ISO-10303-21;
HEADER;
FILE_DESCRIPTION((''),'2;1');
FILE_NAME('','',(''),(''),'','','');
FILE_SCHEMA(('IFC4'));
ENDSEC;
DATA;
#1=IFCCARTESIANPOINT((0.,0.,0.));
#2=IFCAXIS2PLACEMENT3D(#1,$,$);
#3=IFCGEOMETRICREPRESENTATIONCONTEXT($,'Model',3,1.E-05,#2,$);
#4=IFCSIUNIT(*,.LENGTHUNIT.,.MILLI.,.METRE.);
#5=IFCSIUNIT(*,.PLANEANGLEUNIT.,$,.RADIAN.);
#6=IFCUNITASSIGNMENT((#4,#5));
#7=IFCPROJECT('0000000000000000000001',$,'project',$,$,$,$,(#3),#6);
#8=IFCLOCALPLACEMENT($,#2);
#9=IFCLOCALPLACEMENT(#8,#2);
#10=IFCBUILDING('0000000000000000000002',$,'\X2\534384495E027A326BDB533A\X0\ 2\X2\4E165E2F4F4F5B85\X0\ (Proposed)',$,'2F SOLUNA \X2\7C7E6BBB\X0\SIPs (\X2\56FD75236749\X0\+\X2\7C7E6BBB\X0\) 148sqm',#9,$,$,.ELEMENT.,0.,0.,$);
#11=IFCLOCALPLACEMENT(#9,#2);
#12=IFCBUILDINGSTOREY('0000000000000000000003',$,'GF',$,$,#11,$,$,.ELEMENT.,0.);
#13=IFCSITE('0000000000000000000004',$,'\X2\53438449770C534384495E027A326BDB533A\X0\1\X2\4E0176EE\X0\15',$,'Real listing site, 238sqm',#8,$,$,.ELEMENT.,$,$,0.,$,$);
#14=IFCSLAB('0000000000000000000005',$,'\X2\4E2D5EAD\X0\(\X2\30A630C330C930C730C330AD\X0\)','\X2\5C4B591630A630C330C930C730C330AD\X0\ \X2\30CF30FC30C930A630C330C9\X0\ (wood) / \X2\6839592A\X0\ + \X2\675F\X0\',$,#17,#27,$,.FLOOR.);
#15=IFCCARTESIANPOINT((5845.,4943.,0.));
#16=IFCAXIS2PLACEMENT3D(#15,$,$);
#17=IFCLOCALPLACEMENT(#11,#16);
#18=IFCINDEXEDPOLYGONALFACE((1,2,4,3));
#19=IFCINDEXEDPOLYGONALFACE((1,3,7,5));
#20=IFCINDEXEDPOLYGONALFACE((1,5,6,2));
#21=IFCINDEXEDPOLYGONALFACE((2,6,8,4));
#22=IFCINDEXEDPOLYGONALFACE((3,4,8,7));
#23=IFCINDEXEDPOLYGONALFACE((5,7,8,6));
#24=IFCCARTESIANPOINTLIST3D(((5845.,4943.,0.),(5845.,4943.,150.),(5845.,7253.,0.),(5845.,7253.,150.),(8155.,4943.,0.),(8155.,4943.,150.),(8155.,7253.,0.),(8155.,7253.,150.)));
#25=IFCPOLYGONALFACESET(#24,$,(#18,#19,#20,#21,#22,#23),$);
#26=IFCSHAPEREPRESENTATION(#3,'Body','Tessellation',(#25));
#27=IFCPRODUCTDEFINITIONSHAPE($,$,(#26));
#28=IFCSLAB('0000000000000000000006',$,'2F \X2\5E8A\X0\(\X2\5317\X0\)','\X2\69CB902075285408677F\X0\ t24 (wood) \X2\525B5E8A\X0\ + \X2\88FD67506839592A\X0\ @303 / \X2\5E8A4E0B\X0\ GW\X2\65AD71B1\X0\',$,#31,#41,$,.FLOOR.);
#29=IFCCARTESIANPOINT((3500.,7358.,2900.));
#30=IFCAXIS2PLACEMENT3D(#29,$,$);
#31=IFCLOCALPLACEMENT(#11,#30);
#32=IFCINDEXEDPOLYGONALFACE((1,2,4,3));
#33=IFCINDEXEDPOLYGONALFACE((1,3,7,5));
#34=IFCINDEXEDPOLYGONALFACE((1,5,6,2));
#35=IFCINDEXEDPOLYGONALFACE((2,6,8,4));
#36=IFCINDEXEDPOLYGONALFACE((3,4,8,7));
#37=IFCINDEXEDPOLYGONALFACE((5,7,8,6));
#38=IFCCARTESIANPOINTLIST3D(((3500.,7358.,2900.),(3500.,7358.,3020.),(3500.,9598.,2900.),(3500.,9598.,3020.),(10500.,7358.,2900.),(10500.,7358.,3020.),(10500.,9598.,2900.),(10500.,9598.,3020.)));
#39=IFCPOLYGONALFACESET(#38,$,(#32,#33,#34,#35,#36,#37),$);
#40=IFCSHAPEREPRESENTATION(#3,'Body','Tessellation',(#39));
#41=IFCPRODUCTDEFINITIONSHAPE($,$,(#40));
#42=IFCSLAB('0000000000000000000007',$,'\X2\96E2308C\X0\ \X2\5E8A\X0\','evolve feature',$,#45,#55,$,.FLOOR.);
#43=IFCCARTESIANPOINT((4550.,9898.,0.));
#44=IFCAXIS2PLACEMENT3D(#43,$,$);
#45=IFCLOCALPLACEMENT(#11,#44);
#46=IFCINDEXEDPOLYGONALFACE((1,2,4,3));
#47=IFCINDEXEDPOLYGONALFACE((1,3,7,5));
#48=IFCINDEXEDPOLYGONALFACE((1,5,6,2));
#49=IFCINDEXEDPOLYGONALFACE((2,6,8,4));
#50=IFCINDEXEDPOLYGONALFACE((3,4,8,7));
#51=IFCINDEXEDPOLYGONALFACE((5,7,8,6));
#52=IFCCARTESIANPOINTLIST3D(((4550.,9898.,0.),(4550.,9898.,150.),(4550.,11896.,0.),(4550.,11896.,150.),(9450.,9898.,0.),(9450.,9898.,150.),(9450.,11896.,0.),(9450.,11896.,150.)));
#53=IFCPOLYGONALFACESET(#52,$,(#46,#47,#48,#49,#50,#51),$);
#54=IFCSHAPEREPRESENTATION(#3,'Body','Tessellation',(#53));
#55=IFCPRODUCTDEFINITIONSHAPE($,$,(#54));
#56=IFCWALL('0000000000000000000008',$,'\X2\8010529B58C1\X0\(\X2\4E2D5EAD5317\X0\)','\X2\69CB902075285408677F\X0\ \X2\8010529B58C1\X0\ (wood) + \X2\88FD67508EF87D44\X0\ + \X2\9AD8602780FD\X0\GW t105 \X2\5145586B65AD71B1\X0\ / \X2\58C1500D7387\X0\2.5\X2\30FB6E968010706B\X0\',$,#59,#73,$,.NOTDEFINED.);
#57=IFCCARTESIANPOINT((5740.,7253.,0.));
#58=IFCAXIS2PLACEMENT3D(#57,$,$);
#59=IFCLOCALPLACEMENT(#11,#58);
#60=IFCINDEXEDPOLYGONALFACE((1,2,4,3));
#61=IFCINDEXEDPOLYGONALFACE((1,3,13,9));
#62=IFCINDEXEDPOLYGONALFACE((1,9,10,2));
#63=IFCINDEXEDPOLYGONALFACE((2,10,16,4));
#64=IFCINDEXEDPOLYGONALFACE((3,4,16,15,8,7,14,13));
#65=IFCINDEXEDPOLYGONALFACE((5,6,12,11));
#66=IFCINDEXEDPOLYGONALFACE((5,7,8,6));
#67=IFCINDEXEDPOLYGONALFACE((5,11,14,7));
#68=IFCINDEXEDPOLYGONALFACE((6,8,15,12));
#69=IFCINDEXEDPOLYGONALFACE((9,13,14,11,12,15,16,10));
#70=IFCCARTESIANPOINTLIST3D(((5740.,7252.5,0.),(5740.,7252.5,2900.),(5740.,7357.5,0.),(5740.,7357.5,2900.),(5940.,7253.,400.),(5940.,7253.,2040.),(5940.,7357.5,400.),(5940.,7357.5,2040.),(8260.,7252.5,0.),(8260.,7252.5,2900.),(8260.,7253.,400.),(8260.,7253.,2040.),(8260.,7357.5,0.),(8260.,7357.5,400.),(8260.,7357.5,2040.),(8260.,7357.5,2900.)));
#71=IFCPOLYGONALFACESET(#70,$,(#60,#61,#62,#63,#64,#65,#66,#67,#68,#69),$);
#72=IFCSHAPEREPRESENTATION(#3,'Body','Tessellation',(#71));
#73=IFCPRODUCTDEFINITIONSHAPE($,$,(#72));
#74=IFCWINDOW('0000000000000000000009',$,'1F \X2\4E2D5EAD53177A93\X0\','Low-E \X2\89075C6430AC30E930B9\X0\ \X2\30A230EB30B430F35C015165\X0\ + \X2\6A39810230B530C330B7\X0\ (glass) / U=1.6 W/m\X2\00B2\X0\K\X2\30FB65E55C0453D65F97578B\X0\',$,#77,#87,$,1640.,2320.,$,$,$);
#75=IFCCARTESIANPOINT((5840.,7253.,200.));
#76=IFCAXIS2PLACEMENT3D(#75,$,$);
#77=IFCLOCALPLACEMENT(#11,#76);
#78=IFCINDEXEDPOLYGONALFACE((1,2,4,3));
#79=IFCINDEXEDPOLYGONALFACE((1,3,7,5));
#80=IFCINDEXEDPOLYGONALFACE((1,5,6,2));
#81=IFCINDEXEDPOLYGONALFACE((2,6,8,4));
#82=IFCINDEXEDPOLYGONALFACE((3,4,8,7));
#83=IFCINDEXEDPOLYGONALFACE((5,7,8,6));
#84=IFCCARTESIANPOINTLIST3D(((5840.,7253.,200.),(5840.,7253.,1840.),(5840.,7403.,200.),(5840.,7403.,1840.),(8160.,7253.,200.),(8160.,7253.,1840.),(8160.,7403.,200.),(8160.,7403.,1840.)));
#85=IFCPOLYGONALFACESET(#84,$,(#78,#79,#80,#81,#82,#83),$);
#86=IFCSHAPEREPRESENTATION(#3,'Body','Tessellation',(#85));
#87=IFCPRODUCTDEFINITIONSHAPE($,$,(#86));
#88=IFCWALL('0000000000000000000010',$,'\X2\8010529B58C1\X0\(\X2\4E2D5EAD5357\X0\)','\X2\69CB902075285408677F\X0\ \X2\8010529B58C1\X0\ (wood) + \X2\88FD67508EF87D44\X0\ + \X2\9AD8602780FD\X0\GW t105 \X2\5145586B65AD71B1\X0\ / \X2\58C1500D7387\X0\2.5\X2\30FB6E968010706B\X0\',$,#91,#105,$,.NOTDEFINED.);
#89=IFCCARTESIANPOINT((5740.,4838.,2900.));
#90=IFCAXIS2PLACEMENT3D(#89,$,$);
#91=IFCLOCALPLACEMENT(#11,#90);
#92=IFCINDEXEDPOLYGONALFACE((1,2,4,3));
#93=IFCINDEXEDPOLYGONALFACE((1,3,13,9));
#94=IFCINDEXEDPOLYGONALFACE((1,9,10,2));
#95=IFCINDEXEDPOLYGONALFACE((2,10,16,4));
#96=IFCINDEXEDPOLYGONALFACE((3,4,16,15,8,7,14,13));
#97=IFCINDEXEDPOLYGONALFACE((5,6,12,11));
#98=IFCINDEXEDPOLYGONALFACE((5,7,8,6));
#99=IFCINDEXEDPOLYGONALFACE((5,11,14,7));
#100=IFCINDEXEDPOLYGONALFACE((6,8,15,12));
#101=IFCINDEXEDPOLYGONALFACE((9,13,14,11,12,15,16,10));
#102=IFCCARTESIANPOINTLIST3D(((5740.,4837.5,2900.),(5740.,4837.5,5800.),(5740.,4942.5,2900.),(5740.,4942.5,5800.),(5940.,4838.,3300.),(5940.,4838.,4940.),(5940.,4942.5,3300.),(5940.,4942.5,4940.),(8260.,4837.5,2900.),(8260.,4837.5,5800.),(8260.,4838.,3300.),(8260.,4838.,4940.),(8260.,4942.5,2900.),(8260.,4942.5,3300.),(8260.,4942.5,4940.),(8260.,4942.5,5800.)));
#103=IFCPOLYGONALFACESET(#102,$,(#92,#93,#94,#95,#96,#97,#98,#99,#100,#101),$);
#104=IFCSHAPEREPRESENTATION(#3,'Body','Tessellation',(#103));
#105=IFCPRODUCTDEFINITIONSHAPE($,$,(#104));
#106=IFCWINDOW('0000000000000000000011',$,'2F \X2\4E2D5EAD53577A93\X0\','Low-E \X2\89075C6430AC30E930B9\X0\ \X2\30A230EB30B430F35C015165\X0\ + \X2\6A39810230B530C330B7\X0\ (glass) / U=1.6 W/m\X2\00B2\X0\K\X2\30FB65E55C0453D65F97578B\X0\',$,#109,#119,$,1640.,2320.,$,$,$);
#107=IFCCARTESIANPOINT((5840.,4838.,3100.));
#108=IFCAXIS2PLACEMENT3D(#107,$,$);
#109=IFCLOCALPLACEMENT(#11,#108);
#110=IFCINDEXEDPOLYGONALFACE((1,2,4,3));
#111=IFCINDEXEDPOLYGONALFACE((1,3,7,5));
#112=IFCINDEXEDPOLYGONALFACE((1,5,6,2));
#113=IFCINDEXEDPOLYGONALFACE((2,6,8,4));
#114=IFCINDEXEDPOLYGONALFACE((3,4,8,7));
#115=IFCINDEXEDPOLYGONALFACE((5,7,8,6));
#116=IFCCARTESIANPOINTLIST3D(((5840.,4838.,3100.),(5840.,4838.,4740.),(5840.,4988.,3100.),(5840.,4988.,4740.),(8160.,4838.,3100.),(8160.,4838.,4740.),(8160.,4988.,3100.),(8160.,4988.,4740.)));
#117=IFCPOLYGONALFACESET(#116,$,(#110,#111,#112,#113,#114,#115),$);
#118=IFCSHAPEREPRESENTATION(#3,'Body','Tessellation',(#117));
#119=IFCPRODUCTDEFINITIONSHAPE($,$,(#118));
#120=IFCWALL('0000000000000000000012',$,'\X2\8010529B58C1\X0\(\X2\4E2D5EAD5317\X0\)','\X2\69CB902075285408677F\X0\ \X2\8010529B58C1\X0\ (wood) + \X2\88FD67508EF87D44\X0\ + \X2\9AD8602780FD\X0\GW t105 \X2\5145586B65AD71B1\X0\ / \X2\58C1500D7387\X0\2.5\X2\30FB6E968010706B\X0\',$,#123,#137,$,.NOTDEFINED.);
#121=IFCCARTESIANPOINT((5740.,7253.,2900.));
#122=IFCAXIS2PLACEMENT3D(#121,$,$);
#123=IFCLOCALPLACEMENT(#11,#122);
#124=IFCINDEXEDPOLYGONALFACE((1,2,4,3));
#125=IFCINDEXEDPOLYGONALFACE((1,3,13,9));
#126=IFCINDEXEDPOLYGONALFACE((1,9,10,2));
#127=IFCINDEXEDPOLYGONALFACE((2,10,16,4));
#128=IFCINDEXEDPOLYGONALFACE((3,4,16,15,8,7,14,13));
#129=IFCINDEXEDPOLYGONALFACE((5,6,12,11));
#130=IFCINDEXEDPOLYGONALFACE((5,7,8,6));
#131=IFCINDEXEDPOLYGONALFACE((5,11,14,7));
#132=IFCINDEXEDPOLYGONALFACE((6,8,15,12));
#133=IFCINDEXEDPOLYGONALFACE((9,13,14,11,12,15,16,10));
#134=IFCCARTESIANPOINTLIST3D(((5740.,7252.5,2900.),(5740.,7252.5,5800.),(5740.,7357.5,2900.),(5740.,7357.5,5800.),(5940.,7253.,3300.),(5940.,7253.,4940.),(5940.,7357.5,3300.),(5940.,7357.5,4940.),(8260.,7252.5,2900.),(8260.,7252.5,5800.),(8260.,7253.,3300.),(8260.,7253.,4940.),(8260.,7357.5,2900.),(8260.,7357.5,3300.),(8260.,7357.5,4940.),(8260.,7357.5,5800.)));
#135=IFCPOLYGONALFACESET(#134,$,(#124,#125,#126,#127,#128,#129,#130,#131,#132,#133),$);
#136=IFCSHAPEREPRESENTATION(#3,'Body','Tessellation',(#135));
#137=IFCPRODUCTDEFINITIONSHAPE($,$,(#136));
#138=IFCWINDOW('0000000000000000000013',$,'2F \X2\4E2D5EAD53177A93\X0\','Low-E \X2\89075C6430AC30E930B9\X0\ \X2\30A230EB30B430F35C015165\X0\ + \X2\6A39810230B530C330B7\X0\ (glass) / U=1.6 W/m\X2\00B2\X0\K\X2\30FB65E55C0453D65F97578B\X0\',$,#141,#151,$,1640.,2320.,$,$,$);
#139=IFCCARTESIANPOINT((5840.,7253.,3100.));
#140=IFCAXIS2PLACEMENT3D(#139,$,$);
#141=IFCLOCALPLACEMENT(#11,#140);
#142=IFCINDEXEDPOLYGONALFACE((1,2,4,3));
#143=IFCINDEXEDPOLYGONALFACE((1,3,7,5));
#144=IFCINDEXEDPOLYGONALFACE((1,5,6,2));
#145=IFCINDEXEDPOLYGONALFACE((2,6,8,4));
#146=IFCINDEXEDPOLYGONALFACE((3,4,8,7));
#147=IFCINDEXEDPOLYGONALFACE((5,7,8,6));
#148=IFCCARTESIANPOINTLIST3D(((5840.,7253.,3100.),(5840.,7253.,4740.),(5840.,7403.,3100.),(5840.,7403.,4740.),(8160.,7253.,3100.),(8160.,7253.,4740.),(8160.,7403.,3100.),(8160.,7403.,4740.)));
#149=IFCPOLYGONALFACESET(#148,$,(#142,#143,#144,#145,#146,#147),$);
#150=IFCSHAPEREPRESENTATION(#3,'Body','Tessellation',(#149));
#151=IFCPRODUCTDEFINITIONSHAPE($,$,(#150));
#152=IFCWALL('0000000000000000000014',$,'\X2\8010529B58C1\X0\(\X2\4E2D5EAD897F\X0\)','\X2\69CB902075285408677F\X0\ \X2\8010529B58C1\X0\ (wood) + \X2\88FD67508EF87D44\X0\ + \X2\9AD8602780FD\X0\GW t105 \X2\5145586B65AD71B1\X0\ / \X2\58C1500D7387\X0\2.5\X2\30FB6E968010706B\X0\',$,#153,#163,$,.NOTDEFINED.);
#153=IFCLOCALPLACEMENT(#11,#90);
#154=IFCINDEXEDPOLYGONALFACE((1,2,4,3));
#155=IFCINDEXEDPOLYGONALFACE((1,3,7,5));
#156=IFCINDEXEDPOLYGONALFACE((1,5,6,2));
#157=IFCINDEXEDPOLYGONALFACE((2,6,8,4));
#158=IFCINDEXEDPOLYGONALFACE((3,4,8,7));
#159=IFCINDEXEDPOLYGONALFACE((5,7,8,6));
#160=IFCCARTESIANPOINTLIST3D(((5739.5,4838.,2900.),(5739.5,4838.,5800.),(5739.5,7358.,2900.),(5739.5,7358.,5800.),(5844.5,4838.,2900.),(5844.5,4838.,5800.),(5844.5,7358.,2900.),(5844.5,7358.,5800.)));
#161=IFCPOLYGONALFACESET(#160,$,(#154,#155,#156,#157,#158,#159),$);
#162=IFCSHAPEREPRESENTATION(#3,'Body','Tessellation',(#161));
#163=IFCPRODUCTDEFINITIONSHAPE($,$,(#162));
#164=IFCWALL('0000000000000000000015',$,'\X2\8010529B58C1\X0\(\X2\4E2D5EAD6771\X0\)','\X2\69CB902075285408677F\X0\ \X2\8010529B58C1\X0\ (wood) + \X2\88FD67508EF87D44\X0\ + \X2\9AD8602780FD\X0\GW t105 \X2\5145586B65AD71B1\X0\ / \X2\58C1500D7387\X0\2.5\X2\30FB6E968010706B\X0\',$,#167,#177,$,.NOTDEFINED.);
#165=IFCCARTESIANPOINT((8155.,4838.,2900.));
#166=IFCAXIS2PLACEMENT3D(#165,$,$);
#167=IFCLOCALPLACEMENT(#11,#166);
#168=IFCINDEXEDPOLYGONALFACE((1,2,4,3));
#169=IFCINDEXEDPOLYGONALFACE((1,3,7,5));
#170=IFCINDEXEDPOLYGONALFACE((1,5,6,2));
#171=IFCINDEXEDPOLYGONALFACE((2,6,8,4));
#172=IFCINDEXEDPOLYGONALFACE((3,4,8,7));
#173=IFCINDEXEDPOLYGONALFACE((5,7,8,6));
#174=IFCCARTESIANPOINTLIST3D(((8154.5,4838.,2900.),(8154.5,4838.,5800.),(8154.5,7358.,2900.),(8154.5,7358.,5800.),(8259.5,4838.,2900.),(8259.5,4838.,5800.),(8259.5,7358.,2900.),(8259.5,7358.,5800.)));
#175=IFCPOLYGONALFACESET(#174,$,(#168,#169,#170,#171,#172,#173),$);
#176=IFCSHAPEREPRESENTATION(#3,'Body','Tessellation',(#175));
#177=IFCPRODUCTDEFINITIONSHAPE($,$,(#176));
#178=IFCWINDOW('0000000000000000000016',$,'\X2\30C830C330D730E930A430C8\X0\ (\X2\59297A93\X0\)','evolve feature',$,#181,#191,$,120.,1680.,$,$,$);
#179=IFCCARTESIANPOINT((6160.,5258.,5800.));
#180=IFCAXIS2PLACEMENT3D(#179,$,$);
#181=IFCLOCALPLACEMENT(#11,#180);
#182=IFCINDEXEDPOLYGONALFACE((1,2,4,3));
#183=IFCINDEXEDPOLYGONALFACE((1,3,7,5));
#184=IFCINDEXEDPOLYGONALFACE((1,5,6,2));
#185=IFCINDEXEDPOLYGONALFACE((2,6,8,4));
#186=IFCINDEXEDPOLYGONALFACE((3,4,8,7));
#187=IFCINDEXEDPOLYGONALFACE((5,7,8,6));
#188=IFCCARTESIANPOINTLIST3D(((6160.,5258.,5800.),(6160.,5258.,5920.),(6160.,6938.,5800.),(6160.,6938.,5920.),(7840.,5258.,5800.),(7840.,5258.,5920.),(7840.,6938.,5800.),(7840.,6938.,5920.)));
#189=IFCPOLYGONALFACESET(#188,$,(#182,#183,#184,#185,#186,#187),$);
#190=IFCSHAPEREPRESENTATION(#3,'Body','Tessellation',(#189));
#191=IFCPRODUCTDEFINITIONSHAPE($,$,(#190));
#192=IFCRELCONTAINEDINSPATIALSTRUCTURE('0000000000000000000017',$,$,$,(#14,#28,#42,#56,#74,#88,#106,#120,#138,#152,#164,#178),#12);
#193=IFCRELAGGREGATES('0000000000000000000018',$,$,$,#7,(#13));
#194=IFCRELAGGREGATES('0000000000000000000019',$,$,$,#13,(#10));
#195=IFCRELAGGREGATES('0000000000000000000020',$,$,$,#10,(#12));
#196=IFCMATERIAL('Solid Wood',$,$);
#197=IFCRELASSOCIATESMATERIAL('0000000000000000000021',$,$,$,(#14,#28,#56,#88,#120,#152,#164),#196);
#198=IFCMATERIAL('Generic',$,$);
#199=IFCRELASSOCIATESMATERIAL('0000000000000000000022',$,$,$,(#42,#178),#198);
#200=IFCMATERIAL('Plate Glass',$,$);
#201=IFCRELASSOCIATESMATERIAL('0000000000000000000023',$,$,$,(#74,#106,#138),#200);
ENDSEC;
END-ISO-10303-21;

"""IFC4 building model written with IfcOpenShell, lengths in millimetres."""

from ifc_helpers import new_model, si_unit, frame, frame_2d, origin, place, context, project, spatial, rectangle, extrude, material, element, fill, save


model = new_model("IFC4")

# Units and contexts
model_context = context("Model", 3, precision=1e-05, world=origin())
ifc_project = project(units=[si_unit("LENGTHUNIT", "METRE", prefix="MILLI"), si_unit("PLANEANGLEUNIT", "RADIAN")], contexts=[model_context])

# Site, building, storey
site_placement = place(None, origin())
site = spatial("IfcSite", under=ifc_project, at=site_placement, Name="千葉県千葉市稲毛区1丁目15", ObjectType="Real listing site, 238sqm", CompositionType="ELEMENT", RefElevation=0.0)
building_placement = place(site_placement, origin())
building = spatial("IfcBuilding", under=site, at=building_placement, Name="千葉市稲毛区 2世帯住宅 (Proposed)", ObjectType="2F SOLUNA 籾殻SIPs (国産杉+籾殻) 148sqm", CompositionType="ELEMENT", ElevationOfRefHeight=0.0, ElevationOfTerrain=0.0)
storey_placement = place(building_placement, origin())
storey = spatial("IfcBuildingStorey", under=building, at=storey_placement, Name="GF", CompositionType="ELEMENT", Elevation=0.0)

# Slabs
ifc_material_1 = material(Name="Solid Wood")
slab_1_placement = place(storey_placement, frame((5845.0, 4943.0, 0.0)))
element("IfcSlab", 1, at=slab_1_placement, inside=storey, material=ifc_material_1, Name="中庭(ウッドデッキ)", Description="屋外ウッドデッキ ハードウッド (wood) / 根太 + 束", PredefinedType="FLOOR", context=model_context, shape_type="SweptSolid", body=[
    extrude(rectangle(XDim=2310.0, YDim=2310.0, at=frame_2d((1155.0, 1155.0))), frame((5845.0, 4943.0, 0.0)), (0.0, 0.0, 1.0), 150.0),
])
slab_2_placement = place(storey_placement, frame((3500.0, 7358.0, 2900.0)))
element("IfcSlab", 2, at=slab_2_placement, inside=storey, material=ifc_material_1, Name="2F 床(北)", Description="構造用合板 t24 (wood) 剛床 + 製材根太 @303 / 床下 GW断熱", PredefinedType="FLOOR", context=model_context, shape_type="SweptSolid", body=[
    extrude(rectangle(XDim=7000.0, YDim=2240.0, at=frame_2d((3500.0, 1120.0))), frame((3500.0, 7358.0, 2900.0)), (0.0, 0.0, 1.0), 120.0),
])
ifc_material_2 = material(Name="Generic")
slab_3_placement = place(storey_placement, frame((4550.0, 9898.0, 0.0)))
element("IfcSlab", 3, at=slab_3_placement, inside=storey, material=ifc_material_2, Name="離れ 床", Description="evolve feature", PredefinedType="FLOOR", context=model_context, shape_type="SweptSolid", body=[
    extrude(rectangle(XDim=4900.0, YDim=1998.0, at=frame_2d((2450.0, 999.0))), frame((4550.0, 9898.0, 0.0)), (0.0, 0.0, 1.0), 150.0),
])

# Wall, opening, window
wall_1_placement = place(storey_placement, frame((5740.0, 7253.0, 0.0)))
wall_1 = element("IfcWall", 4, at=wall_1_placement, inside=storey, material=ifc_material_1, Name="耐力壁(中庭北)", Description="構造用合板 耐力壁 (wood) + 製材軸組 + 高性能GW t105 充填断熱 / 壁倍率2.5・準耐火", PredefinedType="NOTDEFINED", context=model_context, shape_type="SweptSolid", body=[
    extrude(rectangle(XDim=2520.0, YDim=105.0, at=frame_2d((1260.0, 52.0))), frame((5740.0, 7253.0, 0.0)), (0.0, 0.0, 1.0), 2900.0),
])
opening_1_placement = place(storey_placement, frame((5840.0, 7253.0, 200.0)))
opening_1 = element("IfcOpeningElement", 5, at=opening_1_placement, cuts=wall_1, PredefinedType="NOTDEFINED", context=model_context, shape_type="SweptSolid", body=[
    extrude(rectangle(XDim=2320.0, YDim=150.0, at=frame_2d((1160.0, 75.0))), frame((5840.0, 7253.0, 200.0)), (0.0, 0.0, 1.0), 1640.0),
])
ifc_material_3 = material(Name="Plate Glass")
window_1_placement = place(storey_placement, frame((5840.0, 7253.0, 200.0)))
window_1 = element("IfcWindow", 6, at=window_1_placement, inside=storey, material=ifc_material_3, Name="1F 中庭北窓", Description="Low-E 複層ガラス アルゴン封入 + 樹脂サッシ (glass) / U=1.6 W/m²K・日射取得型", OverallHeight=1640.0, OverallWidth=2320.0, context=model_context, shape_type="SweptSolid", body=[
    extrude(rectangle(XDim=2320.0, YDim=150.0, at=frame_2d((1160.0, 75.0))), frame((5840.0, 7253.0, 200.0)), (0.0, 0.0, 1.0), 1640.0),
])
fill(opening_1, window_1)

# Walls, openings, windows
wall_2_placement = place(storey_placement, frame((5740.0, 4838.0, 2900.0)))
wall_2 = element("IfcWall", 7, at=wall_2_placement, inside=storey, material=ifc_material_1, Name="耐力壁(中庭南)", Description="構造用合板 耐力壁 (wood) + 製材軸組 + 高性能GW t105 充填断熱 / 壁倍率2.5・準耐火", PredefinedType="NOTDEFINED", context=model_context, shape_type="SweptSolid", body=[
    extrude(rectangle(XDim=2520.0, YDim=105.0, at=frame_2d((1260.0, 52.0))), frame((5740.0, 4838.0, 2900.0)), (0.0, 0.0, 1.0), 2900.0),
])
opening_2_placement = place(storey_placement, frame((5840.0, 4838.0, 3100.0)))
opening_2 = element("IfcOpeningElement", 8, at=opening_2_placement, cuts=wall_2, PredefinedType="NOTDEFINED", context=model_context, shape_type="SweptSolid", body=[
    extrude(rectangle(XDim=2320.0, YDim=150.0, at=frame_2d((1160.0, 75.0))), frame((5840.0, 4838.0, 3100.0)), (0.0, 0.0, 1.0), 1640.0),
])
window_2_placement = place(storey_placement, frame((5840.0, 4838.0, 3100.0)))
window_2 = element("IfcWindow", 9, at=window_2_placement, inside=storey, material=ifc_material_3, Name="2F 中庭南窓", Description="Low-E 複層ガラス アルゴン封入 + 樹脂サッシ (glass) / U=1.6 W/m²K・日射取得型", OverallHeight=1640.0, OverallWidth=2320.0, context=model_context, shape_type="SweptSolid", body=[
    extrude(rectangle(XDim=2320.0, YDim=150.0, at=frame_2d((1160.0, 75.0))), frame((5840.0, 4838.0, 3100.0)), (0.0, 0.0, 1.0), 1640.0),
])
fill(opening_2, window_2)
wall_3_placement = place(storey_placement, frame((5740.0, 7253.0, 2900.0)))
wall_3 = element("IfcWall", 10, at=wall_3_placement, inside=storey, material=ifc_material_1, Name="耐力壁(中庭北)", Description="構造用合板 耐力壁 (wood) + 製材軸組 + 高性能GW t105 充填断熱 / 壁倍率2.5・準耐火", PredefinedType="NOTDEFINED", context=model_context, shape_type="SweptSolid", body=[
    extrude(rectangle(XDim=2520.0, YDim=105.0, at=frame_2d((1260.0, 52.0))), frame((5740.0, 7253.0, 2900.0)), (0.0, 0.0, 1.0), 2900.0),
])
opening_3_placement = place(storey_placement, frame((5840.0, 7253.0, 3100.0)))
opening_3 = element("IfcOpeningElement", 11, at=opening_3_placement, cuts=wall_3, PredefinedType="NOTDEFINED", context=model_context, shape_type="SweptSolid", body=[
    extrude(rectangle(XDim=2320.0, YDim=150.0, at=frame_2d((1160.0, 75.0))), frame((5840.0, 7253.0, 3100.0)), (0.0, 0.0, 1.0), 1640.0),
])
window_3_placement = place(storey_placement, frame((5840.0, 7253.0, 3100.0)))
window_3 = element("IfcWindow", 12, at=window_3_placement, inside=storey, material=ifc_material_3, Name="2F 中庭北窓", Description="Low-E 複層ガラス アルゴン封入 + 樹脂サッシ (glass) / U=1.6 W/m²K・日射取得型", OverallHeight=1640.0, OverallWidth=2320.0, context=model_context, shape_type="SweptSolid", body=[
    extrude(rectangle(XDim=2320.0, YDim=150.0, at=frame_2d((1160.0, 75.0))), frame((5840.0, 7253.0, 3100.0)), (0.0, 0.0, 1.0), 1640.0),
])
fill(opening_3, window_3)

# Walls
wall_4_placement = place(storey_placement, frame((5740.0, 4838.0, 2900.0)))
element("IfcWall", 13, at=wall_4_placement, inside=storey, material=ifc_material_1, Name="耐力壁(中庭西)", Description="構造用合板 耐力壁 (wood) + 製材軸組 + 高性能GW t105 充填断熱 / 壁倍率2.5・準耐火", PredefinedType="NOTDEFINED", context=model_context, shape_type="SweptSolid", body=[
    extrude(rectangle(XDim=105.0, YDim=2520.0, at=frame_2d((52.0, 1260.0))), frame((5740.0, 4838.0, 2900.0)), (0.0, 0.0, 1.0), 2900.0),
])
wall_5_placement = place(storey_placement, frame((8155.0, 4838.0, 2900.0)))
element("IfcWall", 14, at=wall_5_placement, inside=storey, material=ifc_material_1, Name="耐力壁(中庭東)", Description="構造用合板 耐力壁 (wood) + 製材軸組 + 高性能GW t105 充填断熱 / 壁倍率2.5・準耐火", PredefinedType="NOTDEFINED", context=model_context, shape_type="SweptSolid", body=[
    extrude(rectangle(XDim=105.0, YDim=2520.0, at=frame_2d((52.0, 1260.0))), frame((8155.0, 4838.0, 2900.0)), (0.0, 0.0, 1.0), 2900.0),
])

# Window
window_4_placement = place(storey_placement, frame((6160.0, 5258.0, 5800.0)))
element("IfcWindow", 15, at=window_4_placement, inside=storey, material=ifc_material_2, Name="トップライト (天窓)", Description="evolve feature", OverallHeight=120.0, OverallWidth=1680.0, context=model_context, shape_type="SweptSolid", body=[
    extrude(rectangle(XDim=1680.0, YDim=1680.0, at=frame_2d((840.0, 840.0))), frame((6160.0, 5258.0, 5800.0)), (0.0, 0.0, 1.0), 120.0),
])

save(model, "model.ifc")
